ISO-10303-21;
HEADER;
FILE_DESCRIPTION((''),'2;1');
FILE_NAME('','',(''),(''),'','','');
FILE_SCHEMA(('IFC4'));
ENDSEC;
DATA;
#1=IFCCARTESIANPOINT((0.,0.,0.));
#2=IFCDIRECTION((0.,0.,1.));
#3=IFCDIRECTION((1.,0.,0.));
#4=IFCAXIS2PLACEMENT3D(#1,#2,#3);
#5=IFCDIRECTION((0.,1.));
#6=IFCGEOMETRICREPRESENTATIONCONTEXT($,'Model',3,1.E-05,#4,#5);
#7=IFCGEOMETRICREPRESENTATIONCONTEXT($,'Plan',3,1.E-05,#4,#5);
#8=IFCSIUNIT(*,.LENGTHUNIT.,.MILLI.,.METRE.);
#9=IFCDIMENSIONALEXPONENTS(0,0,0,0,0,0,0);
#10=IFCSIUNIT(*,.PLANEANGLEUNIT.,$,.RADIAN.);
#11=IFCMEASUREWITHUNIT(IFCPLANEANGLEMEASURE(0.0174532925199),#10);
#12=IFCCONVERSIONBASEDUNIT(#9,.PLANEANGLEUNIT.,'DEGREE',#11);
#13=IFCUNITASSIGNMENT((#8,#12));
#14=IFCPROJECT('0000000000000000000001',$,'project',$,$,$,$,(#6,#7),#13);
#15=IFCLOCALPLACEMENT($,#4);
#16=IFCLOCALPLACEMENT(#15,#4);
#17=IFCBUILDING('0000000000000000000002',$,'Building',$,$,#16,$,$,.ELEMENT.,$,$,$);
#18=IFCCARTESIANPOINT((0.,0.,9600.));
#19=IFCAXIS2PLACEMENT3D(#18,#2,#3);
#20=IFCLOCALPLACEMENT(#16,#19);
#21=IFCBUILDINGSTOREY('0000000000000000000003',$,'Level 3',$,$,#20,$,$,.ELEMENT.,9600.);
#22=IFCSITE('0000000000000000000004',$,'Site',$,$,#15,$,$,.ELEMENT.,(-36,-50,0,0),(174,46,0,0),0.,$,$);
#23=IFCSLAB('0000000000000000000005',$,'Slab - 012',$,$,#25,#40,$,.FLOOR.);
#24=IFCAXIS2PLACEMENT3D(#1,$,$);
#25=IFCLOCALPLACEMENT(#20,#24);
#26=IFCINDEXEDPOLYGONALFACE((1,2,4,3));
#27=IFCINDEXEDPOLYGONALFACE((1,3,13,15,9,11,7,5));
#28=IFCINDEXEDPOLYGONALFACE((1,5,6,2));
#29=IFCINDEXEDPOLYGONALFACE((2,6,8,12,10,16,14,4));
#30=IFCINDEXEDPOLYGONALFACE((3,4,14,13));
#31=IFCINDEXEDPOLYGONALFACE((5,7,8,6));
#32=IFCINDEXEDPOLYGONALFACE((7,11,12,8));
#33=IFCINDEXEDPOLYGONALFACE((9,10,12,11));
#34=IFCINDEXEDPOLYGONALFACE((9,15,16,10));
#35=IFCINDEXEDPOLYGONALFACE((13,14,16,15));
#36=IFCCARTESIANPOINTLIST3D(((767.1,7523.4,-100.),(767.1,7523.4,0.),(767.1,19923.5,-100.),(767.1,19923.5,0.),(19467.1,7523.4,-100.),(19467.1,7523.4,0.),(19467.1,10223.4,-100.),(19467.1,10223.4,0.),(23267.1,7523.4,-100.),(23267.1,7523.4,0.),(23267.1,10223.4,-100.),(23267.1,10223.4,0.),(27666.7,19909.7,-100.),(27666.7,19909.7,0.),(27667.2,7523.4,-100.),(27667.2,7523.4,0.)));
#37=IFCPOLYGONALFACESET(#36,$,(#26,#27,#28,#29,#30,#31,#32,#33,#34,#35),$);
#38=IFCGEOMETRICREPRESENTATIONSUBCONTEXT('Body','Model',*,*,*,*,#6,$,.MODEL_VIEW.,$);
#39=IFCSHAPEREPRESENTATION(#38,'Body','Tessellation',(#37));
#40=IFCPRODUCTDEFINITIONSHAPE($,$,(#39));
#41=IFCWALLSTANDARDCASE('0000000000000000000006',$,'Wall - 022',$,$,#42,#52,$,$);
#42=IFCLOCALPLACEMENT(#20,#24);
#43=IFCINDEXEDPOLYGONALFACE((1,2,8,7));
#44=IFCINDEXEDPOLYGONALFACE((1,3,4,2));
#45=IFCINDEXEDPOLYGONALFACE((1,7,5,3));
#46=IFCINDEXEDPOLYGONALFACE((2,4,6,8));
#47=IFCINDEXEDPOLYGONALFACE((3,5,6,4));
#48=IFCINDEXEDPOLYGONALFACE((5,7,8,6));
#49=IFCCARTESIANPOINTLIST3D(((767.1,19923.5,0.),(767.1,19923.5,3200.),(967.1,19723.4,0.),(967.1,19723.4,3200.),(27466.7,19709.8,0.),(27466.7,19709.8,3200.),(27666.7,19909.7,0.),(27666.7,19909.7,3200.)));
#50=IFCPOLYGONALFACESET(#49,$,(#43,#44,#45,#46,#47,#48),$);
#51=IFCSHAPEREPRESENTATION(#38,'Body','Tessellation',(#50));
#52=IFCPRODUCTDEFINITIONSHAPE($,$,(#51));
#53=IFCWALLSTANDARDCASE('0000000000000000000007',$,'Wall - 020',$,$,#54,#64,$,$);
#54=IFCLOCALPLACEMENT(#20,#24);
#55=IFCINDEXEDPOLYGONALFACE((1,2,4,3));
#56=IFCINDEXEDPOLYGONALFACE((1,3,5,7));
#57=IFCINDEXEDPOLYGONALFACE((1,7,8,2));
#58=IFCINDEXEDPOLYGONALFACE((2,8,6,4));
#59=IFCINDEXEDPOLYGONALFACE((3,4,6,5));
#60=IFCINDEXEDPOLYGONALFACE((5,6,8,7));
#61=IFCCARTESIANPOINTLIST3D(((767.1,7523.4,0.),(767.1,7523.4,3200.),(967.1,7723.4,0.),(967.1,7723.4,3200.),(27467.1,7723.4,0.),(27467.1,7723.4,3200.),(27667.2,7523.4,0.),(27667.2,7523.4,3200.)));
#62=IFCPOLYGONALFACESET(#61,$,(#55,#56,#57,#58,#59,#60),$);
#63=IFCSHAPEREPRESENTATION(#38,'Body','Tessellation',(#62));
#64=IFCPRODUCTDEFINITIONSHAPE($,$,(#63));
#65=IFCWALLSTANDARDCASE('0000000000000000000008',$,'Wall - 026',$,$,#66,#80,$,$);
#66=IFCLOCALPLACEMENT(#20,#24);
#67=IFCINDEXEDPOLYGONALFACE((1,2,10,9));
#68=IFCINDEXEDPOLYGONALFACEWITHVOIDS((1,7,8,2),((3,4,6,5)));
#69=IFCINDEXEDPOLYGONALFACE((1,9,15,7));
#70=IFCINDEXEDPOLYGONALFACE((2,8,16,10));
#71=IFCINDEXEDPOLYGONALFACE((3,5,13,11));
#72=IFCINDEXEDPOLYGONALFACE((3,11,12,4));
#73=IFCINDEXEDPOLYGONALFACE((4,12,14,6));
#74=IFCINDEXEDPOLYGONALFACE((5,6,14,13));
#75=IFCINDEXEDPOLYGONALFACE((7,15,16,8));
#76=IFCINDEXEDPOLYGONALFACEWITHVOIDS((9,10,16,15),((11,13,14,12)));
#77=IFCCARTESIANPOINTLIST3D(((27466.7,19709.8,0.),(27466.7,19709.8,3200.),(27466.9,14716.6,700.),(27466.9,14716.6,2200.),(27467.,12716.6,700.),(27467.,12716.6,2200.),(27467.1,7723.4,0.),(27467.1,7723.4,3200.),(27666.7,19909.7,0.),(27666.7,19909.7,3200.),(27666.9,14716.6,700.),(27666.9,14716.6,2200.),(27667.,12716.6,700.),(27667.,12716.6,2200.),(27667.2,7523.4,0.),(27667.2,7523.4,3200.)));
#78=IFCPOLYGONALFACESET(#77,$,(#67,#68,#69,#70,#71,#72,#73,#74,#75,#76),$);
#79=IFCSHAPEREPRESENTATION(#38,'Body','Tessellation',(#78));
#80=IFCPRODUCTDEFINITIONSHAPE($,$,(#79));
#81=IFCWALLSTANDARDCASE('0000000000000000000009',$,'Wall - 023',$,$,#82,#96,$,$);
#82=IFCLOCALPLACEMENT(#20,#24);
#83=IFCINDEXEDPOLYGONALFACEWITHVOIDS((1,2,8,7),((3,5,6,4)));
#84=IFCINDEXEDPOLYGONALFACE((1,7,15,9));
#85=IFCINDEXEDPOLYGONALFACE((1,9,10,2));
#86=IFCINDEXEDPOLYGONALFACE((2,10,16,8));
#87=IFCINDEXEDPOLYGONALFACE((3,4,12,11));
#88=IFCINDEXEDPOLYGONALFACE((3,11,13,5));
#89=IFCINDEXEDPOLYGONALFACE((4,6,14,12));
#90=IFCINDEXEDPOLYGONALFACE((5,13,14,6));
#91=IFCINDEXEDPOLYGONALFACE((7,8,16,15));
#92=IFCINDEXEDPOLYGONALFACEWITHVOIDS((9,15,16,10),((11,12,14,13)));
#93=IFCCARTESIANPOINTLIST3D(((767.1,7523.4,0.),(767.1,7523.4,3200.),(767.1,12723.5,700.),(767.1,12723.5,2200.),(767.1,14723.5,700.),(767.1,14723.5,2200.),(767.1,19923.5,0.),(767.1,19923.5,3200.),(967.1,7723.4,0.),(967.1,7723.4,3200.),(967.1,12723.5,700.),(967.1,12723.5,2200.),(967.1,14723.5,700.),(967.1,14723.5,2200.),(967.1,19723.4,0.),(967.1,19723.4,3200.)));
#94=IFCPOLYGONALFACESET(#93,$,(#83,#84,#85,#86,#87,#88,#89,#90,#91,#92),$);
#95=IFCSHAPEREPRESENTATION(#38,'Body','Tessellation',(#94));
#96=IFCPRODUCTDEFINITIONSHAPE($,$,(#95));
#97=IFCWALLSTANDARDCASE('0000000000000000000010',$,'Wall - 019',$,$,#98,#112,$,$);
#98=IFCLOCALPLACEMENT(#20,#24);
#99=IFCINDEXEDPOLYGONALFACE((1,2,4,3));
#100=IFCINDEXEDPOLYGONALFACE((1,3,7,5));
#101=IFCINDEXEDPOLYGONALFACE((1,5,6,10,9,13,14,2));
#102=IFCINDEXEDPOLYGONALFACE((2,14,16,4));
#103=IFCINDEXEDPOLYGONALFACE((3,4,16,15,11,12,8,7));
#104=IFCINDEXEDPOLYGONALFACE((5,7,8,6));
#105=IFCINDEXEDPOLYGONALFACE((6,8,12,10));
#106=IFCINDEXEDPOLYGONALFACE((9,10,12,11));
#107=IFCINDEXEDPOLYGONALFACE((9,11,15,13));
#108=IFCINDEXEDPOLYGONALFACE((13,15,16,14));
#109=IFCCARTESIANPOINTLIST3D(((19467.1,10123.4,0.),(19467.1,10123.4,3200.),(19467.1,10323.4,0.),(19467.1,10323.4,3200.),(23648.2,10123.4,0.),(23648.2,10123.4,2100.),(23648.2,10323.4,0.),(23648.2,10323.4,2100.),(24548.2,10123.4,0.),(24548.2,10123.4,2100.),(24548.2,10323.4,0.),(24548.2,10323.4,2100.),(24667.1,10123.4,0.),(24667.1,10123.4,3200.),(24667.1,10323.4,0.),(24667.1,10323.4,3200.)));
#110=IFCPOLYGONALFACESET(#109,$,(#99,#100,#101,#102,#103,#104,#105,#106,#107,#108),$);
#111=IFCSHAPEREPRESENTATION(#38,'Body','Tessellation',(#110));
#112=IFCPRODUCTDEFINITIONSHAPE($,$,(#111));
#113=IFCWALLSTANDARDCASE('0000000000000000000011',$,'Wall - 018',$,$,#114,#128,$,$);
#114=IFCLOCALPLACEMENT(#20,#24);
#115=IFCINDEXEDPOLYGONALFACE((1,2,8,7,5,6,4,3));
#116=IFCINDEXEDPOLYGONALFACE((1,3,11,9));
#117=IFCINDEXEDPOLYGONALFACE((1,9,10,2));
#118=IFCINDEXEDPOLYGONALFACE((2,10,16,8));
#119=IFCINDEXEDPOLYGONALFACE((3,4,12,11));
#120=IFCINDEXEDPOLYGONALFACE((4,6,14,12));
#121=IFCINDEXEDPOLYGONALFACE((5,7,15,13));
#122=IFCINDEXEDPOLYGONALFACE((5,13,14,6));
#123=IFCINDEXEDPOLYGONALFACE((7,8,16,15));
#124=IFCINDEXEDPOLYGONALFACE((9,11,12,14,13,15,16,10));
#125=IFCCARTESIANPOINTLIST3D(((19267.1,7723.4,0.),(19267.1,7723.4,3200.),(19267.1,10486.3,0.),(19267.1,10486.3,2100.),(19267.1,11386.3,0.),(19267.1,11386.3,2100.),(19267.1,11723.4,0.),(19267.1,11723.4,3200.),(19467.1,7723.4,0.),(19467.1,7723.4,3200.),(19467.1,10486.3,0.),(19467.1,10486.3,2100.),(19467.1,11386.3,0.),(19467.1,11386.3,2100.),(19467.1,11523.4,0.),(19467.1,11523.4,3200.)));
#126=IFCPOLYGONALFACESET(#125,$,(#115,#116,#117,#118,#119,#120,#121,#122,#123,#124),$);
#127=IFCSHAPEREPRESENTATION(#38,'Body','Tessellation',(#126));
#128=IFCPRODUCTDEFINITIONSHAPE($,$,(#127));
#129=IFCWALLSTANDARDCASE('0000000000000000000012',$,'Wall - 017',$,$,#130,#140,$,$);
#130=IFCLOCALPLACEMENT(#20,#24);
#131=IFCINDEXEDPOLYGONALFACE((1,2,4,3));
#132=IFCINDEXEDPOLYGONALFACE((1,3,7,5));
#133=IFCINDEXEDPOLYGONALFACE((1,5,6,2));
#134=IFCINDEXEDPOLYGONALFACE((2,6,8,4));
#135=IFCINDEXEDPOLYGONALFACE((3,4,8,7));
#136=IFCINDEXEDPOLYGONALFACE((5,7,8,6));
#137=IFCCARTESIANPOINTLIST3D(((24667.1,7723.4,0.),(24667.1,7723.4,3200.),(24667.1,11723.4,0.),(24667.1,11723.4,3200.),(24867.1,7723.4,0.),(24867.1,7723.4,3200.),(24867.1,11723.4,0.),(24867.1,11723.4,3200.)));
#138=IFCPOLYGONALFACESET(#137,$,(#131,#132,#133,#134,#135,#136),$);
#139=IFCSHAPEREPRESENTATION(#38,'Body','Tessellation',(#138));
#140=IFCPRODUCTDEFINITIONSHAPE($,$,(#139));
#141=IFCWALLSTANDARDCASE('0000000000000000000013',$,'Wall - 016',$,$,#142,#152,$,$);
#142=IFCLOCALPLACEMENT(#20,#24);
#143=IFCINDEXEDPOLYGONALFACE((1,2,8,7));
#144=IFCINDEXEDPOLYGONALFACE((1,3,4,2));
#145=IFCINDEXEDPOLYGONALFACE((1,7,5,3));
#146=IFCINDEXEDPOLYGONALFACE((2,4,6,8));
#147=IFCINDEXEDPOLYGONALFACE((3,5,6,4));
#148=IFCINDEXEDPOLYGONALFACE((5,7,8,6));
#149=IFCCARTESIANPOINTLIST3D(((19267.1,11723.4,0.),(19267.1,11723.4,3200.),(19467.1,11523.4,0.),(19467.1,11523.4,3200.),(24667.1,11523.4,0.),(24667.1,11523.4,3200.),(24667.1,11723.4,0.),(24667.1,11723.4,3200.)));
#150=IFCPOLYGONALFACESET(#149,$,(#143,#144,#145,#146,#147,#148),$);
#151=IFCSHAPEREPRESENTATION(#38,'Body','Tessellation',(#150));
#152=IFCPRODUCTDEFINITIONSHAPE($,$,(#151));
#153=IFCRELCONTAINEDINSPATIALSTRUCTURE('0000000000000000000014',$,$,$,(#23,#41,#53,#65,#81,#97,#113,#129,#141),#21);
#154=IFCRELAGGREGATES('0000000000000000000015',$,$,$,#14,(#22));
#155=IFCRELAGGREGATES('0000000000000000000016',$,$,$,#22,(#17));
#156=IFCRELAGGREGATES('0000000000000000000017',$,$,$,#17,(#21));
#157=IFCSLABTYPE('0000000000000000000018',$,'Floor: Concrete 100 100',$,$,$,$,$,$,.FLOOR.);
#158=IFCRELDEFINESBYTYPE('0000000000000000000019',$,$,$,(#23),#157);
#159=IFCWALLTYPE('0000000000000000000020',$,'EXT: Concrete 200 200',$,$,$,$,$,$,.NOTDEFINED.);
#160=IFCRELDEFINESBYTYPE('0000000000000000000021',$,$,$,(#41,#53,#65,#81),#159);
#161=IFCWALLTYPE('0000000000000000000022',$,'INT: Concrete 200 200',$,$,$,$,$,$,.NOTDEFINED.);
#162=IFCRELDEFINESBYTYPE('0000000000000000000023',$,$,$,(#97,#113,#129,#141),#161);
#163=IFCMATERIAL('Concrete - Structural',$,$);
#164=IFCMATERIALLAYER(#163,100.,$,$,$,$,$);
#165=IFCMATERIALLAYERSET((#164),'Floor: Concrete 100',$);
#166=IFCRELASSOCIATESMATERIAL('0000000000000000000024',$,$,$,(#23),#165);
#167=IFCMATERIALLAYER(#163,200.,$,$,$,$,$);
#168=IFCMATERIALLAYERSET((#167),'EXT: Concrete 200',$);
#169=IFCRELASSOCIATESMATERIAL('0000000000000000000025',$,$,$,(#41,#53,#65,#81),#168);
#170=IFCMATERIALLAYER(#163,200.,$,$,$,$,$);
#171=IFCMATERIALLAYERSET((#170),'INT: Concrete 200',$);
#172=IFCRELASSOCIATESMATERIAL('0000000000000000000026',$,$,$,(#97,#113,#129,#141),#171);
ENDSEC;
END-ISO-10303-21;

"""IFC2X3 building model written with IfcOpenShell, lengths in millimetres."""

from ifc_helpers import new_model, entity, si_unit, converted_unit, direction, frame, origin_with_axes, origin_2d_with_axis, place, context, subcontext, project, spatial, polyline, rectangle, outline, extrude, material, layer, layer_set, layer_usage, type_object, element, save


model = new_model("IFC2X3")

# Units and contexts
model_context = context("Model", 3, precision=1e-05, world=origin_with_axes(), true_north=direction((0.0, 1.0)))
plan_context = context("Plan", 3, precision=1e-05, world=origin_with_axes(), true_north=direction((0.0, 1.0)))
body_context = subcontext(model_context, "Body", "Model", "MODEL_VIEW")
ifc_project = project(units=[si_unit("LENGTHUNIT", "METRE", prefix="MILLI"), converted_unit("PLANEANGLEUNIT", "DEGREE", entity("IfcPlaneAngleMeasure", 0.0174532925199), si_unit("PLANEANGLEUNIT", "RADIAN"), dimensions=[0, 0, 0, 0, 0, 0, 0])], contexts=[model_context, plan_context])

# Site, building, storey
site_placement = place(None, origin_with_axes())
site = spatial("IfcSite", under=ifc_project, at=site_placement, Name="Site", CompositionType="ELEMENT", RefLatitude=(-36, -50, 0, 0), RefLongitude=(174, 46, 0, 0), RefElevation=0.0)
building_placement = place(site_placement, origin_with_axes())
building = spatial("IfcBuilding", under=site, at=building_placement, Name="Building", CompositionType="ELEMENT")
storey_placement = place(building_placement, frame((0.0, 0.0, 9600.0), z_axis=(0.0, 0.0, 1.0), x_axis=(1.0, 0.0, 0.0)))
storey = spatial("IfcBuildingStorey", under=building, at=storey_placement, Name="Level 3", CompositionType="ELEMENT", Elevation=9600.0)

# Slab
ifc_material = material(Name="Concrete - Structural")
ifc_layer_1 = layer(ifc_material, 100.0)
ifc_layer_set_1 = layer_set([ifc_layer_1], Name="Floor: Concrete 100")
ifc_layer_usage_1 = layer_usage(ifc_layer_set_1, "AXIS3", "NEGATIVE", 100.0)
slab_type = type_object("IfcSlabType", Name="Floor: Concrete 100 100", PredefinedType="FLOOR")
slab_placement = place(storey_placement, frame((767.1, 19923.5, 0.0), z_axis=(0.0, 0.0, 1.0), x_axis=(1.0, 0.0, 0.0)))
element("IfcSlab", 1, at=slab_placement, inside=storey, type_object=slab_type, material=ifc_layer_usage_1, Name="Slab - 012", PredefinedType="FLOOR", context=body_context, shape_type="SweptSolid", body=[
    extrude(outline(polyline([(0.0, 0.0), (0.0, -12400.1), (18700.0, -12400.1), (18700.0, -9700.1), (22500.0, -9700.1), (22500.0, -12400.1), (26900.0, -12400.1), (26899.5, -13.8), (0.0, 0.0)])), frame((0.0, 0.0, -100.0), z_axis=(0.0, 0.0, 1.0), x_axis=(1.0, 0.0, 0.0)), (0.0, 0.0, 1.0), 100.0),
])

# Walls
ifc_layer_2 = layer(ifc_material, 200.0)
ifc_layer_set_2 = layer_set([ifc_layer_2], Name="EXT: Concrete 200")
ifc_layer_usage_2 = layer_usage(ifc_layer_set_2, "AXIS2", "POSITIVE", 0.0)
wall_type_1 = type_object("IfcWallType", Name="EXT: Concrete 200 200", PredefinedType="NOTDEFINED")
wall_1_placement = place(storey_placement, frame((967.1, 19723.4, 0.0), z_axis=(0.0, 0.0, 1.0), x_axis=(1.0, -0.000513, 0.0)))
element("IfcWallStandardCase", 2, at=wall_1_placement, inside=storey, type_object=wall_type_1, material=ifc_layer_usage_2, Name="Wall - 022", context=body_context, shape_type="SweptSolid", body=[
    extrude(outline(polyline([(0.0, 0.0), (26499.5, 0.0), (26699.4, 200.0), (-200.1, 200.0), (0.0, 0.0)])), origin_with_axes(), (0.0, 0.0, 1.0), 3200.0),
])
ifc_layer_usage_3 = layer_usage(ifc_layer_set_2, "AXIS2", "POSITIVE", 0.0)
wall_2_placement = place(storey_placement, frame((27667.1, 7723.4, 0.0), z_axis=(0.0, 0.0, 1.0), x_axis=(-1.0, 0.0, 0.0)))
element("IfcWallStandardCase", 3, at=wall_2_placement, inside=storey, type_object=wall_type_1, material=ifc_layer_usage_3, Name="Wall - 020", context=body_context, shape_type="SweptSolid", body=[
    extrude(outline(polyline([(200.0, 0.0), (26700.0, 0.0), (26900.0, 200.0), (0.0, 200.0), (200.0, 0.0)])), origin_with_axes(), (0.0, 0.0, 1.0), 3200.0),
])

# Walls, openings
ifc_layer_usage_4 = layer_usage(ifc_layer_set_2, "AXIS2", "POSITIVE", -200.0)
wall_3_placement = place(storey_placement, frame((27666.7, 19709.7, 0.0), z_axis=(0.0, 0.0, 1.0), x_axis=(0.000039, -1.0, 0.0)))
wall_3 = element("IfcWallStandardCase", 4, at=wall_3_placement, inside=storey, type_object=wall_type_1, material=ifc_layer_usage_4, Name="Wall - 026", context=body_context, shape_type="SweptSolid", body=[
    extrude(outline(polyline([(-0.1, -200.0), (11986.3, -200.0), (12186.3, 0.0), (-200.0, 0.0), (-0.1, -200.0)])), origin_with_axes(), (0.0, 0.0, 1.0), 3200.0),
])
opening_1_placement = place(wall_3_placement, frame((5993.2, 0.0, 700.0), z_axis=(0.0, 0.0, 1.0), x_axis=(1.0, 0.0, 0.0)))
element("IfcOpeningElement", 5, at=opening_1_placement, cuts=wall_3, context=body_context, shape_type="SweptSolid", body=[
    extrude(rectangle(XDim=2000.0, YDim=1500.0, at=origin_2d_with_axis()), frame((0.0, -200.0, 750.0), z_axis=(0.0, 1.0, 0.0), x_axis=(1.0, 0.0, 0.0)), (0.0, 0.0, 1.0), 600.0),
])
ifc_layer_usage_5 = layer_usage(ifc_layer_set_2, "AXIS2", "POSITIVE", -200.0)
wall_4_placement = place(storey_placement, frame((967.1, 19723.4, 0.0), z_axis=(0.0, 0.0, 1.0), x_axis=(0.0, -1.0, 0.0)))
wall_4 = element("IfcWallStandardCase", 6, at=wall_4_placement, inside=storey, type_object=wall_type_1, material=ifc_layer_usage_5, Name="Wall - 023", context=body_context, shape_type="SweptSolid", body=[
    extrude(outline(polyline([(-200.1, -200.0), (12200.0, -200.0), (12000.0, 0.0), (0.0, 0.0), (-200.1, -200.0)])), origin_with_axes(), (0.0, 0.0, 1.0), 3200.0),
])
opening_2_placement = place(wall_4_placement, frame((5999.9, 0.0, 700.0), z_axis=(0.0, 0.0, 1.0), x_axis=(1.0, 0.0, 0.0)))
element("IfcOpeningElement", 7, at=opening_2_placement, cuts=wall_4, context=body_context, shape_type="SweptSolid", body=[
    extrude(rectangle(XDim=2000.0, YDim=1500.0, at=origin_2d_with_axis()), frame((0.0, 200.0, 750.0), z_axis=(0.0, -1.0, 0.0), x_axis=(-1.0, 0.0, 0.0)), (0.0, 0.0, 1.0), 600.0),
])
ifc_layer_3 = layer(ifc_material, 200.0)
ifc_layer_set_3 = layer_set([ifc_layer_3], Name="INT: Concrete 200")
ifc_layer_usage_6 = layer_usage(ifc_layer_set_3, "AXIS2", "POSITIVE", -200.0)
wall_type_2 = type_object("IfcWallType", Name="INT: Concrete 200 200", PredefinedType="NOTDEFINED")
wall_5_placement = place(storey_placement, frame((19467.1, 10323.4, 0.0), z_axis=(0.0, 0.0, 1.0), x_axis=(1.0, 0.0, 0.0)))
wall_5 = element("IfcWallStandardCase", 8, at=wall_5_placement, inside=storey, type_object=wall_type_2, material=ifc_layer_usage_6, Name="Wall - 019", context=body_context, shape_type="SweptSolid", body=[
    extrude(outline(polyline([(0.0, -200.0), (5200.0, -200.0), (5200.0, 0.0), (0.0, 0.0), (0.0, -200.0)])), origin_with_axes(), (0.0, 0.0, 1.0), 3200.0),
])
opening_3_placement = place(wall_5_placement, frame((4631.0, 0.0, 0.0), z_axis=(0.0, 0.0, 1.0), x_axis=(1.0, 0.0, 0.0)))
element("IfcOpeningElement", 9, at=opening_3_placement, cuts=wall_5, context=body_context, shape_type="SweptSolid", body=[
    extrude(rectangle(XDim=900.0, YDim=2100.0, at=origin_2d_with_axis()), frame((0.0, 200.0, 1050.0), z_axis=(0.0, 1.0, 0.0), x_axis=(1.0, 0.0, 0.0)), (0.0, 0.0, -1.0), 600.0),
])
ifc_layer_usage_7 = layer_usage(ifc_layer_set_3, "AXIS2", "POSITIVE", -200.0)
wall_6_placement = place(storey_placement, frame((19467.1, 11523.4, 0.0), z_axis=(0.0, 0.0, 1.0), x_axis=(0.0, -1.0, 0.0)))
wall_6 = element("IfcWallStandardCase", 10, at=wall_6_placement, inside=storey, type_object=wall_type_2, material=ifc_layer_usage_7, Name="Wall - 018", context=body_context, shape_type="SweptSolid", body=[
    extrude(outline(polyline([(-200.0, -200.0), (3800.0, -200.0), (3800.0, 0.0), (0.0, 0.0), (-200.0, -200.0)])), origin_with_axes(), (0.0, 0.0, 1.0), 3200.0),
])
opening_4_placement = place(wall_6_placement, frame((587.1, 0.0, 0.0), z_axis=(0.0, 0.0, 1.0), x_axis=(1.0, 0.0, 0.0)))
element("IfcOpeningElement", 11, at=opening_4_placement, cuts=wall_6, context=body_context, shape_type="SweptSolid", body=[
    extrude(rectangle(XDim=900.0, YDim=2100.0, at=origin_2d_with_axis()), frame((0.0, -200.0, 1050.0), z_axis=(0.0, 1.0, 0.0), x_axis=(1.0, 0.0, 0.0)), (0.0, 0.0, 1.0), 600.0),
])

# Walls
ifc_layer_usage_8 = layer_usage(ifc_layer_set_3, "AXIS2", "POSITIVE", 0.0)
wall_7_placement = place(storey_placement, frame((24667.1, 11723.4, 0.0), z_axis=(0.0, 0.0, 1.0), x_axis=(0.0, -1.0, 0.0)))
element("IfcWallStandardCase", 12, at=wall_7_placement, inside=storey, type_object=wall_type_2, material=ifc_layer_usage_8, Name="Wall - 017", context=body_context, shape_type="SweptSolid", body=[
    extrude(outline(polyline([(0.0, 0.0), (4000.0, 0.0), (4000.0, 200.0), (0.0, 200.0), (0.0, 0.0)])), origin_with_axes(), (0.0, 0.0, 1.0), 3200.0),
])
ifc_layer_usage_9 = layer_usage(ifc_layer_set_3, "AXIS2", "POSITIVE", 0.0)
wall_8_placement = place(storey_placement, frame((19467.1, 11523.4, 0.0), z_axis=(0.0, 0.0, 1.0), x_axis=(1.0, 0.0, 0.0)))
element("IfcWallStandardCase", 13, at=wall_8_placement, inside=storey, type_object=wall_type_2, material=ifc_layer_usage_9, Name="Wall - 016", context=body_context, shape_type="SweptSolid", body=[
    extrude(outline(polyline([(0.0, 0.0), (5200.0, 0.0), (5200.0, 200.0), (-200.0, 200.0), (0.0, 0.0)])), origin_with_axes(), (0.0, 0.0, 1.0), 3200.0),
])

save(model, "model.ifc")
